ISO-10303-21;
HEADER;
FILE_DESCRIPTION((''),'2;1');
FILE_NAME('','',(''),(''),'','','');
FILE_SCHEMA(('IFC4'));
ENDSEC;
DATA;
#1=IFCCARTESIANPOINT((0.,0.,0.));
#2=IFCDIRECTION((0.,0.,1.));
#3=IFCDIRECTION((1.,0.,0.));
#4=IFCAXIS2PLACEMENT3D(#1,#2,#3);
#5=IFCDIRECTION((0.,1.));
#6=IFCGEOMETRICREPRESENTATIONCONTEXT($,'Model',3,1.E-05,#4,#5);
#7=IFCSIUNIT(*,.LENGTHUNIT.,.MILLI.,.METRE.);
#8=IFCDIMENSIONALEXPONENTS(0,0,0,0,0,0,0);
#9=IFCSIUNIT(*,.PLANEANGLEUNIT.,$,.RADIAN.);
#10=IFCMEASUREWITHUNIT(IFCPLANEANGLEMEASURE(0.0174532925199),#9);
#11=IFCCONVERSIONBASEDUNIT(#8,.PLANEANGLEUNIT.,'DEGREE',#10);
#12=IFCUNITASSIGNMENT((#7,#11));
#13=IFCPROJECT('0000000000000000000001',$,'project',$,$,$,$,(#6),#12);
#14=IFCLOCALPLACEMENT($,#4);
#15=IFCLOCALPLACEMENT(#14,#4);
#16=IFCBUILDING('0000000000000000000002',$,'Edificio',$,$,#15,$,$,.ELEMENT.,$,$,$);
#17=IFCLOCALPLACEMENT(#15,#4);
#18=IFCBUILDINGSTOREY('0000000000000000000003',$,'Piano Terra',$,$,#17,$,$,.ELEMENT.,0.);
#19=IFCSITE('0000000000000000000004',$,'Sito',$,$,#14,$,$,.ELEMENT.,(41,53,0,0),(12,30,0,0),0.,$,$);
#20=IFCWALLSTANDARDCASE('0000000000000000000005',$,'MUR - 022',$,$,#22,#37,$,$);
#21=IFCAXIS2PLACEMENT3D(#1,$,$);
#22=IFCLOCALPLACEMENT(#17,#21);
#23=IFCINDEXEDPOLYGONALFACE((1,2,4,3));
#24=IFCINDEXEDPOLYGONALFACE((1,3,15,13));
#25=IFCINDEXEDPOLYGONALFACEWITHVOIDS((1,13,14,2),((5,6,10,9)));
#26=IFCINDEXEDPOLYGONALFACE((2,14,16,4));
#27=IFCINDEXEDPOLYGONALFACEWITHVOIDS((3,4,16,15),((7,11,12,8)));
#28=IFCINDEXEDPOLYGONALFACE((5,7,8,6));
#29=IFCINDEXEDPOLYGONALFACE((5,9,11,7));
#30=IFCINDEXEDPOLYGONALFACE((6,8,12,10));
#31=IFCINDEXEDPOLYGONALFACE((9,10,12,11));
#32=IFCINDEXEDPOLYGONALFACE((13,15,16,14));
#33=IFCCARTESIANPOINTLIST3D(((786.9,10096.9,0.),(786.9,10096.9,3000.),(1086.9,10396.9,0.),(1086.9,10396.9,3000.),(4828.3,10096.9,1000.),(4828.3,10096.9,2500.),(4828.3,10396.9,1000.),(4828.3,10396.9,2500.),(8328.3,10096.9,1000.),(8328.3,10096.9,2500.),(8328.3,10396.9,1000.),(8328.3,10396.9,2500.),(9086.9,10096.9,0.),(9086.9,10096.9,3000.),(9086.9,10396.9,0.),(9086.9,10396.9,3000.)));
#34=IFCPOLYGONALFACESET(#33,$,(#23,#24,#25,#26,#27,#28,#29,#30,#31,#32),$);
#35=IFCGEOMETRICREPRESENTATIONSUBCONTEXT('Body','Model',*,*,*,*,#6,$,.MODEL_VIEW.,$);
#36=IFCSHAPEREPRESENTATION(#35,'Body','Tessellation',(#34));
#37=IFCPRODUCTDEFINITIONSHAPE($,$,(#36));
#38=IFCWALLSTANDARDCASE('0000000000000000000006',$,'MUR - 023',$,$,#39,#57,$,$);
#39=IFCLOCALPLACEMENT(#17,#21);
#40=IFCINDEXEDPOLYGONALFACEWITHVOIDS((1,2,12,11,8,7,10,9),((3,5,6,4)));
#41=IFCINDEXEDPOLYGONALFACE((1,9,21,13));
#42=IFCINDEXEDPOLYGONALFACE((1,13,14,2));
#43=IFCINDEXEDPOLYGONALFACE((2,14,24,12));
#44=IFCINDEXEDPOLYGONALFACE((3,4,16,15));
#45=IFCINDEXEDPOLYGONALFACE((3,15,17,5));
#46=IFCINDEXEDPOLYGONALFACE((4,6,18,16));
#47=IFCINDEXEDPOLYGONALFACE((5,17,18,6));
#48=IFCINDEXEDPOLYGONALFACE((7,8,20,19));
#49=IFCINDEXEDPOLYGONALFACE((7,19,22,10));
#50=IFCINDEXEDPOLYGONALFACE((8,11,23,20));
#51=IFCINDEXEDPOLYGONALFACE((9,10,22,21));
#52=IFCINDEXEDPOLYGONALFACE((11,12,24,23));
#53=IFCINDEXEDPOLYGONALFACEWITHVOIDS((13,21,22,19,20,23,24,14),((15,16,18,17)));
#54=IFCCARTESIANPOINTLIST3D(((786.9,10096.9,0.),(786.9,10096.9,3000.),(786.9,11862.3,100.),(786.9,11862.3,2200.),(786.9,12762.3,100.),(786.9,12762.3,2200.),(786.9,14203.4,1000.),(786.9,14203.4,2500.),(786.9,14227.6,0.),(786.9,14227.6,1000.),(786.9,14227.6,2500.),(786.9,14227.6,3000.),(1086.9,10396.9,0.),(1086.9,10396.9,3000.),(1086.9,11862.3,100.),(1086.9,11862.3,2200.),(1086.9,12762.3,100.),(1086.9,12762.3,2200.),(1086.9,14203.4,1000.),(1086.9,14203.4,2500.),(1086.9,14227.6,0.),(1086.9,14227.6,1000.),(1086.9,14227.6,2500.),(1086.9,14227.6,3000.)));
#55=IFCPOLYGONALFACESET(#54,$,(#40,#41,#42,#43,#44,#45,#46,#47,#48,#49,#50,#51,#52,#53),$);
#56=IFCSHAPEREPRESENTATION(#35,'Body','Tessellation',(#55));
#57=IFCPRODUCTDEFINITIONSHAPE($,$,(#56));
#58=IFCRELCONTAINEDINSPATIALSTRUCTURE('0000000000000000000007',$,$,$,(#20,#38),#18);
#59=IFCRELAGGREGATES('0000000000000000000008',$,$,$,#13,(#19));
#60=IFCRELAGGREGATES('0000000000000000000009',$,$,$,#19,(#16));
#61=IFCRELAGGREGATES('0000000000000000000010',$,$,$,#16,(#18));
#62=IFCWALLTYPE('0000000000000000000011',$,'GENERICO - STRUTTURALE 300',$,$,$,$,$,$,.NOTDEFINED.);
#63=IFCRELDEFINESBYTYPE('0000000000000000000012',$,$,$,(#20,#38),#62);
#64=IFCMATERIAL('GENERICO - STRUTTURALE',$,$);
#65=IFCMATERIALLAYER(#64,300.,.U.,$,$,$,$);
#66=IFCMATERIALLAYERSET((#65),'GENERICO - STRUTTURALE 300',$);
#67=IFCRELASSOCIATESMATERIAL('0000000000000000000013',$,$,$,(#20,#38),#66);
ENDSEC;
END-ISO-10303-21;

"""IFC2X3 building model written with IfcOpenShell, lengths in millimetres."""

from ifc_helpers import new_model, entity, si_unit, converted_unit, direction, frame, origin_with_axes, origin_2d_with_axis, place, context, subcontext, project, spatial, polyline, rectangle, outline, extrude, material, layer, layer_set, layer_usage, type_object, element, save


model = new_model("IFC2X3")

# Units and contexts
model_context = context("Model", 3, precision=1e-05, world=origin_with_axes(), true_north=direction((0.0, 1.0)))
body_context = subcontext(model_context, "Body", "Model", "MODEL_VIEW")
ifc_project = project(units=[si_unit("LENGTHUNIT", "METRE", prefix="MILLI"), converted_unit("PLANEANGLEUNIT", "DEGREE", entity("IfcPlaneAngleMeasure", 0.0174532925199), si_unit("PLANEANGLEUNIT", "RADIAN"), dimensions=[0, 0, 0, 0, 0, 0, 0])], contexts=[model_context])

# Site, building, storey
site_placement = place(None, origin_with_axes())
site = spatial("IfcSite", under=ifc_project, at=site_placement, Name="Sito", CompositionType="ELEMENT", RefLatitude=(41, 53, 0, 0), RefLongitude=(12, 30, 0, 0), RefElevation=0.0)
building_placement = place(site_placement, origin_with_axes())
building = spatial("IfcBuilding", under=site, at=building_placement, Name="Edificio", CompositionType="ELEMENT")
storey_placement = place(building_placement, origin_with_axes())
storey = spatial("IfcBuildingStorey", under=building, at=storey_placement, Name="Piano Terra", CompositionType="ELEMENT", Elevation=0.0)

# Shared definitions
ifc_material_1 = material(Name="GENERICO - STRUTTURALE")

# Shared definitions
ifc_layer_1 = layer(ifc_material_1, 300.0, ventilated="UNKNOWN")
ifc_layer_set_1 = layer_set([ifc_layer_1], Name="GENERICO - STRUTTURALE 300")
wall_type = type_object("IfcWallType", Name="GENERICO - STRUTTURALE 300", PredefinedType="NOTDEFINED")

# Wall, opening
ifc_layer_usage_1 = layer_usage(ifc_layer_set_1, "AXIS2", "POSITIVE", 0.0)
wall_1_placement = place(storey_placement, frame((9386.9, 10396.9, 0.0), z_axis=(0.0, 0.0, 1.0), x_axis=(-1.0, 0.0, 0.0)))
wall_1 = element("IfcWallStandardCase", 1, at=wall_1_placement, inside=storey, type_object=wall_type, material=ifc_layer_usage_1, Name="MUR - 022", context=body_context, shape_type="SweptSolid", body=[
    extrude(outline(polyline([(300.0, 0.0), (8300.0, 0.0), (8600.0, 300.0), (300.0, 300.0), (300.0, 0.0)])), origin_with_axes(), (0.0, 0.0, 1.0), 3000.0),
])
opening_1_placement = place(wall_1_placement, frame((2808.6, 0.0, 1000.0), z_axis=(0.0, 0.0, 1.0), x_axis=(1.0, 0.0, 0.0)))
element("IfcOpeningElement", 2, at=opening_1_placement, cuts=wall_1, context=body_context, shape_type="SweptSolid", body=[
    extrude(rectangle(XDim=3500.0, YDim=1500.0, at=origin_2d_with_axis()), frame((0.0, -300.0, 750.0), z_axis=(0.0, -1.0, 0.0), x_axis=(-1.0, 0.0, 0.0)), (0.0, 0.0, -1.0), 900.0),
])

# Wall, openings
ifc_layer_usage_2 = layer_usage(ifc_layer_set_1, "AXIS2", "POSITIVE", -300.0)
wall_2_placement = place(storey_placement, frame((786.9, 10396.9, 0.0), z_axis=(0.0, 0.0, 1.0), x_axis=(0.0, 1.0, 0.0)))
wall_2 = element("IfcWallStandardCase", 3, at=wall_2_placement, inside=storey, type_object=wall_type, material=ifc_layer_usage_2, Name="MUR - 023", context=body_context, shape_type="SweptSolid", body=[
    extrude(outline(polyline([(0.0, -300.0), (3830.7, -300.0), (3830.7, 0.0), (-300.0, 0.0), (0.0, -300.0)])), origin_with_axes(), (0.0, 0.0, 1.0), 3000.0),
])
opening_2_placement = place(wall_2_placement, frame((5556.4, 0.0, 1000.0), z_axis=(0.0, 0.0, 1.0), x_axis=(1.0, 0.0, 0.0)))
element("IfcOpeningElement", 4, at=opening_2_placement, cuts=wall_2, context=body_context, shape_type="SweptSolid", body=[
    extrude(rectangle(XDim=3500.0, YDim=1500.0, at=origin_2d_with_axis()), frame((0.0, -300.0, 750.0), z_axis=(0.0, -1.0, 0.0), x_axis=(-1.0, 0.0, 0.0)), (0.0, 0.0, -1.0), 900.0),
])
opening_3_placement = place(wall_2_placement, frame((1915.4, 0.0, 100.0), z_axis=(0.0, 0.0, 1.0), x_axis=(1.0, 0.0, 0.0)))
element("IfcOpeningElement", 5, at=opening_3_placement, cuts=wall_2, context=body_context, shape_type="SweptSolid", body=[
    extrude(rectangle(XDim=900.0, YDim=2100.0, at=origin_2d_with_axis()), frame((0.0, 300.0, 1050.0), z_axis=(0.0, -1.0, 0.0), x_axis=(-1.0, 0.0, 0.0)), (0.0, 0.0, 1.0), 900.0),
    extrude(rectangle(XDim=974.0, YDim=2137.0, at=origin_2d_with_axis()), frame((0.0, 0.0, 1068.5), z_axis=(0.0, -1.0, 0.0), x_axis=(-1.0, 0.0, 0.0)), (0.0, 0.0, -1.0), 300.0),
    extrude(rectangle(XDim=974.0, YDim=2137.0, at=origin_2d_with_axis()), frame((0.0, -300.0, 1068.5), z_axis=(0.0, 1.0, 0.0), x_axis=(-1.0, 0.0, 0.0)), (0.0, 0.0, -1.0), 300.0),
])

save(model, "model.ifc")
